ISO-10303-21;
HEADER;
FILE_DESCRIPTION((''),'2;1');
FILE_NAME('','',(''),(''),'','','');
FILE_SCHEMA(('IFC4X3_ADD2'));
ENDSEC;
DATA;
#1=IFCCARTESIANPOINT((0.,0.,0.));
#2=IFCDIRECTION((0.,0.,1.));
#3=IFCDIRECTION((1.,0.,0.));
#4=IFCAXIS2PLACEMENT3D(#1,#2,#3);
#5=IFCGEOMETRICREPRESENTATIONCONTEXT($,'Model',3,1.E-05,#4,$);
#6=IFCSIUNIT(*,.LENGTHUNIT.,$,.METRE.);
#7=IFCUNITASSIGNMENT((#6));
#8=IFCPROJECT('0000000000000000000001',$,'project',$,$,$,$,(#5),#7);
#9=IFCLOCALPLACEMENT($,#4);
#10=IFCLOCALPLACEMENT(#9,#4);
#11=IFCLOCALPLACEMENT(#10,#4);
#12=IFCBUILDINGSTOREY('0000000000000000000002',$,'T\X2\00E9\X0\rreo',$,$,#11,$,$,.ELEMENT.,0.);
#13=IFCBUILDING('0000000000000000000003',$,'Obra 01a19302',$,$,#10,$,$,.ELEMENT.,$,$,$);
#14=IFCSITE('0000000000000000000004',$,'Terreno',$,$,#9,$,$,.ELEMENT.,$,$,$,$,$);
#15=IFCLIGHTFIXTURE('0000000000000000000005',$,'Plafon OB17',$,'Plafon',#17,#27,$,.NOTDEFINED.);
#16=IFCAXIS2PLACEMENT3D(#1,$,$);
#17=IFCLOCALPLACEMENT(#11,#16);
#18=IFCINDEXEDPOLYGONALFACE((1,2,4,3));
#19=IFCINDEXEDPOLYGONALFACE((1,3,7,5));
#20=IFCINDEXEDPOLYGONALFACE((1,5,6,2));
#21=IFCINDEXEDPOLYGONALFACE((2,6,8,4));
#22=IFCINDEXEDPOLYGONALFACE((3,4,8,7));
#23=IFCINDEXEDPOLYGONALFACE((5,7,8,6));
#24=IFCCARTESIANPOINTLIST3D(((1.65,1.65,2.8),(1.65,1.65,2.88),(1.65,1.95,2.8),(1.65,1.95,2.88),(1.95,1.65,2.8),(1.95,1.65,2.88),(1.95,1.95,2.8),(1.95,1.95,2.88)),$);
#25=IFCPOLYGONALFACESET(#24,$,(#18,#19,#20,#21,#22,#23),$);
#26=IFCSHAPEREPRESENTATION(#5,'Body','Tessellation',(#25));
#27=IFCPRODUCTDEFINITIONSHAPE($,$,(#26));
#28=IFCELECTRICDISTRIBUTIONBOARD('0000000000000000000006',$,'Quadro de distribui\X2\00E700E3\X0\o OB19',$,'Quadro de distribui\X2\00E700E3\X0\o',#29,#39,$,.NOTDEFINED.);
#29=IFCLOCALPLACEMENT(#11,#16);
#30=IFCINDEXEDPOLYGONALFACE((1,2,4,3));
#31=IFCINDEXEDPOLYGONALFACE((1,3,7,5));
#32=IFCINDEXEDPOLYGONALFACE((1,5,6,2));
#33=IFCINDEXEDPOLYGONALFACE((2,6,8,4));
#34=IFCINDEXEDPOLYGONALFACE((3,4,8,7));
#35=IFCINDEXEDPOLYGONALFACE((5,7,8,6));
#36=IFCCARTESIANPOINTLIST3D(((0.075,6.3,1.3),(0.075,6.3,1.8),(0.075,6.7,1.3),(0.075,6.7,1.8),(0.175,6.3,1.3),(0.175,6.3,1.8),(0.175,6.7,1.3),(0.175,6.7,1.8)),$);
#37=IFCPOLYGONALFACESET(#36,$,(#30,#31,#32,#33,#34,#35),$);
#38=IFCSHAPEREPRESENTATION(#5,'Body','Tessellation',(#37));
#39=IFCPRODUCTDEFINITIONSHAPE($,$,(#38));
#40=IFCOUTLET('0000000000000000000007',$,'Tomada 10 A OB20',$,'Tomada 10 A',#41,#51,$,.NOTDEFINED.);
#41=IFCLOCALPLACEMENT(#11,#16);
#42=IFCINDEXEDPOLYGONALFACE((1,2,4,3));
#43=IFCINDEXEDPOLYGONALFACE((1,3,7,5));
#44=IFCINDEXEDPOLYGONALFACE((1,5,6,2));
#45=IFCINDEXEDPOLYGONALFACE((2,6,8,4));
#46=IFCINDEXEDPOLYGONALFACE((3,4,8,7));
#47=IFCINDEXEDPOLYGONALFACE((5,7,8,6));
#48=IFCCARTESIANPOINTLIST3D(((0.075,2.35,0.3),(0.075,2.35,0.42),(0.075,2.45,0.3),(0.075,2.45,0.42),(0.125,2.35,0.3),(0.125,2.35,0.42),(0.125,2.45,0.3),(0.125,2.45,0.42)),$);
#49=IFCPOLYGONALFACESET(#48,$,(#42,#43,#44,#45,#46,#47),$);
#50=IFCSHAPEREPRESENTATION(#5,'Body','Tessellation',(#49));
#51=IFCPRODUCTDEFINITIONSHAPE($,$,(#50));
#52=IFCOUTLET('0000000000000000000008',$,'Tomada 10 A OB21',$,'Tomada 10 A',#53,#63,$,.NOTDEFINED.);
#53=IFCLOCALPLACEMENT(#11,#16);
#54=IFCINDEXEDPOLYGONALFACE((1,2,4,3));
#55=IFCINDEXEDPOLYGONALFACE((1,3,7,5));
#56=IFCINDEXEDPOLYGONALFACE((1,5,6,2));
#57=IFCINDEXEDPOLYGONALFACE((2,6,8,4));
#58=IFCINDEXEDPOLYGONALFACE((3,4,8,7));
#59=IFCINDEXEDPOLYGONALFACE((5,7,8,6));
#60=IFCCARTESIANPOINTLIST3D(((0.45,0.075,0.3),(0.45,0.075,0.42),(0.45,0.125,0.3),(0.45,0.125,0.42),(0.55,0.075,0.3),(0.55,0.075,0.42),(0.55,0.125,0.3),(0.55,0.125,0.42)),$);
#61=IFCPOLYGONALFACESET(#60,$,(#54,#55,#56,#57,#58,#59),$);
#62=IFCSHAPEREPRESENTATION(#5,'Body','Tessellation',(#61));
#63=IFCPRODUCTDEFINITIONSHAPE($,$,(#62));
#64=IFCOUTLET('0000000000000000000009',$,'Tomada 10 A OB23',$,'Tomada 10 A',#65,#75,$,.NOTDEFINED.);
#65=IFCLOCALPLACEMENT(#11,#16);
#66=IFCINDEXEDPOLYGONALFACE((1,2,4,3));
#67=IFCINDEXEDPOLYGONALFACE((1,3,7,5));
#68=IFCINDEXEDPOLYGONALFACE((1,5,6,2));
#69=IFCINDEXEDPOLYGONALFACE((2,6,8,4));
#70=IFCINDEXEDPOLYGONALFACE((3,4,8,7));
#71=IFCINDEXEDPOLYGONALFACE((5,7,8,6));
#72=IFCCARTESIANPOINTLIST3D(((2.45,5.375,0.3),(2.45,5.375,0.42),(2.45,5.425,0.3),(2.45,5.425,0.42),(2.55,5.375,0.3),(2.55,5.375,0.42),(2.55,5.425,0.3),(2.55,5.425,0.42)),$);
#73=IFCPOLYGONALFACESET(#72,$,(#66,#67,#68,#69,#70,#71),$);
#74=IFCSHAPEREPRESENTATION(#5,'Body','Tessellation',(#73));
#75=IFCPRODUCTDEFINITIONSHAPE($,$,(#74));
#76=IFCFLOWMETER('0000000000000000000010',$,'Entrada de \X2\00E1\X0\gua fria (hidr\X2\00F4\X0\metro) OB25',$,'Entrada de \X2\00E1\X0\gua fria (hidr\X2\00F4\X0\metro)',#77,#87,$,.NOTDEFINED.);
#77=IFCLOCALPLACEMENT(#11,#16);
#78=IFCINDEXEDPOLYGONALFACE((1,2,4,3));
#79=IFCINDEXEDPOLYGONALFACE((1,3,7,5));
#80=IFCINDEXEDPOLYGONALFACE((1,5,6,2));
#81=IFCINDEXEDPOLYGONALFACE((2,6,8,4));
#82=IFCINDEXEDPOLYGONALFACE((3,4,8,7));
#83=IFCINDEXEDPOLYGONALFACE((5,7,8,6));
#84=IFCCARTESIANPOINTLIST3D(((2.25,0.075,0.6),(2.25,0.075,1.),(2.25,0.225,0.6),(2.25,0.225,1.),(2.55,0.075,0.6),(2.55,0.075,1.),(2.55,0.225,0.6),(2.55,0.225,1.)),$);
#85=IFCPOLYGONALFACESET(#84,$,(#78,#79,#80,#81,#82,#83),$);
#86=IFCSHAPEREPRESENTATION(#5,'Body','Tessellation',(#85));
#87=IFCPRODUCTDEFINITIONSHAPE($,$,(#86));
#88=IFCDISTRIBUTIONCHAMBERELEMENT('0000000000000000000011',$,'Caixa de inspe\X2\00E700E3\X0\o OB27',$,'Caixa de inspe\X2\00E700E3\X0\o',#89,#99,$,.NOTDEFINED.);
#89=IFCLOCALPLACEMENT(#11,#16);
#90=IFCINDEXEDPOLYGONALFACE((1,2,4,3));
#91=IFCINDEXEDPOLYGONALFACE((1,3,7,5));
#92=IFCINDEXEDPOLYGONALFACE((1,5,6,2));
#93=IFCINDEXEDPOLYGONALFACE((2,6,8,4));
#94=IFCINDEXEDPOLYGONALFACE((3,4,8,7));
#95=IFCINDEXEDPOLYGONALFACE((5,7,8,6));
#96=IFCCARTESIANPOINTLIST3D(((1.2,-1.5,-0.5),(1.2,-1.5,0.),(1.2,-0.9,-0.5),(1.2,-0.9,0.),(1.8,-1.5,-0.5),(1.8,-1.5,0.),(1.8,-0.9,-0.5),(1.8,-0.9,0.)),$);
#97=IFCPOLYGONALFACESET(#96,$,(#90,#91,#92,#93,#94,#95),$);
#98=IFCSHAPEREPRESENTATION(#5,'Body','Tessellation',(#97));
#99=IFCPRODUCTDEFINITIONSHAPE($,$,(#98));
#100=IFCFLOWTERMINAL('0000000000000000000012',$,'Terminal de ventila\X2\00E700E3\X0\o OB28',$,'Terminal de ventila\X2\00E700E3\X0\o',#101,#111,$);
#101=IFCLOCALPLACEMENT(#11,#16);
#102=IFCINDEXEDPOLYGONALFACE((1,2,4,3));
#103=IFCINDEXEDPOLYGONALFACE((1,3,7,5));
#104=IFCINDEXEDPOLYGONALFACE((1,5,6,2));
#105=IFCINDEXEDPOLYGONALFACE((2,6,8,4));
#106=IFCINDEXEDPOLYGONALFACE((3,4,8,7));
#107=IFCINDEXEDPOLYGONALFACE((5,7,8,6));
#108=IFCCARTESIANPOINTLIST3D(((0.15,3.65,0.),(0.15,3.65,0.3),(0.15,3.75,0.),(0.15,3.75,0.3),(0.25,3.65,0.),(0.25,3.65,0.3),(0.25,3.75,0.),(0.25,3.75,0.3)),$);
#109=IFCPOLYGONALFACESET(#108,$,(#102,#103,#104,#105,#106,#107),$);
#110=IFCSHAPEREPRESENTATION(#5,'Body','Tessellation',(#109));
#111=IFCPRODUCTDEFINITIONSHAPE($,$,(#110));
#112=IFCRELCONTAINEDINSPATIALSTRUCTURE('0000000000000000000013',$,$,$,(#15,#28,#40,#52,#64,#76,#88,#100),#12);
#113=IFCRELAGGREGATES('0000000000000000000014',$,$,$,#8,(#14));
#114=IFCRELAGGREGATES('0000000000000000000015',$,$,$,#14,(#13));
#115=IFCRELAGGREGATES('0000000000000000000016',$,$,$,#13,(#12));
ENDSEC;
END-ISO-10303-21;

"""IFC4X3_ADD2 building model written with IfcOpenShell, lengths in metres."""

from ifc_helpers import new_model, si_unit, frame, frame_2d, origin_with_axes, place, context, project, spatial, rectangle, extrude, element, save


model = new_model("IFC4X3_ADD2")

# Units and contexts
model_context = context("Model", 3, precision=1e-05, world=origin_with_axes())
ifc_project = project(units=[si_unit("LENGTHUNIT", "METRE")], contexts=[model_context])

# Site, building, storey
site_placement = place(None, origin_with_axes())
site = spatial("IfcSite", under=ifc_project, at=site_placement, Name="Terreno", CompositionType="ELEMENT")
building_placement = place(site_placement, origin_with_axes())
building = spatial("IfcBuilding", under=site, at=building_placement, Name="Obra 01a19302", CompositionType="ELEMENT")
storey_placement = place(building_placement, origin_with_axes())
storey = spatial("IfcBuildingStorey", under=building, at=storey_placement, Name="Térreo", CompositionType="ELEMENT", Elevation=0.0)

# Light fixture
light_fixture_placement = place(storey_placement, frame((1.65, 1.65, 2.8), z_axis=(0.0, 0.0, 1.0), x_axis=(1.0, 0.0, 0.0)))
element("IfcLightFixture", 1, at=light_fixture_placement, inside=storey, Name="Plafon OB17", ObjectType="Plafon", PredefinedType="NOTDEFINED", context=model_context, shape_type="SweptSolid", body=[
    extrude(rectangle(XDim=0.3, YDim=0.3, at=frame_2d((0.15, 0.15))), origin_with_axes(), (0.0, 0.0, 1.0), 0.08),
])

# Electric distribution board
electric_distribution_board_placement = place(storey_placement, frame((0.075, 6.7, 1.3), z_axis=(0.0, 0.0, 1.0), x_axis=(0.0, -1.0, 0.0)))
element("IfcElectricDistributionBoard", 2, at=electric_distribution_board_placement, inside=storey, Name="Quadro de distribuição OB19", ObjectType="Quadro de distribuição", PredefinedType="NOTDEFINED", context=model_context, shape_type="SweptSolid", body=[
    extrude(rectangle(XDim=0.4, YDim=0.1, at=frame_2d((0.2, 0.05))), origin_with_axes(), (0.0, 0.0, 1.0), 0.5),
])

# Outlets
for number, where, z_axis, x_axis, name in (
    (3, (0.075, 2.45, 0.3), (0.0, 0.0, 1.0), (0.0, -1.0, 0.0), "Tomada 10 A OB20"),
    (4, (0.45, 0.075, 0.3), (0.0, 0.0, 1.0), (1.0, 0.0, 0.0), "Tomada 10 A OB21"),
    (5, (2.55, 5.425, 0.3), (0.0, 0.0, 1.0), (-1.0, 0.0, 0.0), "Tomada 10 A OB23"),
):
    element("IfcOutlet", number, at=place(storey_placement, frame(where, z_axis=z_axis, x_axis=x_axis)), inside=storey, Name=name, ObjectType="Tomada 10 A", PredefinedType="NOTDEFINED", context=model_context, shape_type="SweptSolid", body=[
        extrude(rectangle(XDim=0.1, YDim=0.05, at=frame_2d((0.05, 0.025))), origin_with_axes(), (0.0, 0.0, 1.0), 0.12),
    ])

# Flow meter
flow_meter_placement = place(storey_placement, frame((2.25, 0.075, 0.6), z_axis=(0.0, 0.0, 1.0), x_axis=(1.0, 0.0, 0.0)))
element("IfcFlowMeter", 6, at=flow_meter_placement, inside=storey, Name="Entrada de água fria (hidrômetro) OB25", ObjectType="Entrada de água fria (hidrômetro)", PredefinedType="NOTDEFINED", context=model_context, shape_type="SweptSolid", body=[
    extrude(rectangle(XDim=0.3, YDim=0.15, at=frame_2d((0.15, 0.075))), origin_with_axes(), (0.0, 0.0, 1.0), 0.4),
])

# Distribution chamber element
distribution_chamber_element_placement = place(storey_placement, frame((1.2, -1.5, -0.5), z_axis=(0.0, 0.0, 1.0), x_axis=(1.0, 0.0, 0.0)))
element("IfcDistributionChamberElement", 7, at=distribution_chamber_element_placement, inside=storey, Name="Caixa de inspeção OB27", ObjectType="Caixa de inspeção", PredefinedType="NOTDEFINED", context=model_context, shape_type="SweptSolid", body=[
    extrude(rectangle(XDim=0.6, YDim=0.6, at=frame_2d((0.3, 0.3))), origin_with_axes(), (0.0, 0.0, 1.0), 0.5),
])

# Flow terminal
flow_terminal_placement = place(storey_placement, frame((0.15, 3.65, 0.0), z_axis=(0.0, 0.0, 1.0), x_axis=(1.0, 0.0, 0.0)))
element("IfcFlowTerminal", 8, at=flow_terminal_placement, inside=storey, Name="Terminal de ventilação OB28", ObjectType="Terminal de ventilação", context=model_context, shape_type="SweptSolid", body=[
    extrude(rectangle(XDim=0.1, YDim=0.1, at=frame_2d((0.05, 0.05))), origin_with_axes(), (0.0, 0.0, 1.0), 0.3),
])

save(model, "model.ifc")
